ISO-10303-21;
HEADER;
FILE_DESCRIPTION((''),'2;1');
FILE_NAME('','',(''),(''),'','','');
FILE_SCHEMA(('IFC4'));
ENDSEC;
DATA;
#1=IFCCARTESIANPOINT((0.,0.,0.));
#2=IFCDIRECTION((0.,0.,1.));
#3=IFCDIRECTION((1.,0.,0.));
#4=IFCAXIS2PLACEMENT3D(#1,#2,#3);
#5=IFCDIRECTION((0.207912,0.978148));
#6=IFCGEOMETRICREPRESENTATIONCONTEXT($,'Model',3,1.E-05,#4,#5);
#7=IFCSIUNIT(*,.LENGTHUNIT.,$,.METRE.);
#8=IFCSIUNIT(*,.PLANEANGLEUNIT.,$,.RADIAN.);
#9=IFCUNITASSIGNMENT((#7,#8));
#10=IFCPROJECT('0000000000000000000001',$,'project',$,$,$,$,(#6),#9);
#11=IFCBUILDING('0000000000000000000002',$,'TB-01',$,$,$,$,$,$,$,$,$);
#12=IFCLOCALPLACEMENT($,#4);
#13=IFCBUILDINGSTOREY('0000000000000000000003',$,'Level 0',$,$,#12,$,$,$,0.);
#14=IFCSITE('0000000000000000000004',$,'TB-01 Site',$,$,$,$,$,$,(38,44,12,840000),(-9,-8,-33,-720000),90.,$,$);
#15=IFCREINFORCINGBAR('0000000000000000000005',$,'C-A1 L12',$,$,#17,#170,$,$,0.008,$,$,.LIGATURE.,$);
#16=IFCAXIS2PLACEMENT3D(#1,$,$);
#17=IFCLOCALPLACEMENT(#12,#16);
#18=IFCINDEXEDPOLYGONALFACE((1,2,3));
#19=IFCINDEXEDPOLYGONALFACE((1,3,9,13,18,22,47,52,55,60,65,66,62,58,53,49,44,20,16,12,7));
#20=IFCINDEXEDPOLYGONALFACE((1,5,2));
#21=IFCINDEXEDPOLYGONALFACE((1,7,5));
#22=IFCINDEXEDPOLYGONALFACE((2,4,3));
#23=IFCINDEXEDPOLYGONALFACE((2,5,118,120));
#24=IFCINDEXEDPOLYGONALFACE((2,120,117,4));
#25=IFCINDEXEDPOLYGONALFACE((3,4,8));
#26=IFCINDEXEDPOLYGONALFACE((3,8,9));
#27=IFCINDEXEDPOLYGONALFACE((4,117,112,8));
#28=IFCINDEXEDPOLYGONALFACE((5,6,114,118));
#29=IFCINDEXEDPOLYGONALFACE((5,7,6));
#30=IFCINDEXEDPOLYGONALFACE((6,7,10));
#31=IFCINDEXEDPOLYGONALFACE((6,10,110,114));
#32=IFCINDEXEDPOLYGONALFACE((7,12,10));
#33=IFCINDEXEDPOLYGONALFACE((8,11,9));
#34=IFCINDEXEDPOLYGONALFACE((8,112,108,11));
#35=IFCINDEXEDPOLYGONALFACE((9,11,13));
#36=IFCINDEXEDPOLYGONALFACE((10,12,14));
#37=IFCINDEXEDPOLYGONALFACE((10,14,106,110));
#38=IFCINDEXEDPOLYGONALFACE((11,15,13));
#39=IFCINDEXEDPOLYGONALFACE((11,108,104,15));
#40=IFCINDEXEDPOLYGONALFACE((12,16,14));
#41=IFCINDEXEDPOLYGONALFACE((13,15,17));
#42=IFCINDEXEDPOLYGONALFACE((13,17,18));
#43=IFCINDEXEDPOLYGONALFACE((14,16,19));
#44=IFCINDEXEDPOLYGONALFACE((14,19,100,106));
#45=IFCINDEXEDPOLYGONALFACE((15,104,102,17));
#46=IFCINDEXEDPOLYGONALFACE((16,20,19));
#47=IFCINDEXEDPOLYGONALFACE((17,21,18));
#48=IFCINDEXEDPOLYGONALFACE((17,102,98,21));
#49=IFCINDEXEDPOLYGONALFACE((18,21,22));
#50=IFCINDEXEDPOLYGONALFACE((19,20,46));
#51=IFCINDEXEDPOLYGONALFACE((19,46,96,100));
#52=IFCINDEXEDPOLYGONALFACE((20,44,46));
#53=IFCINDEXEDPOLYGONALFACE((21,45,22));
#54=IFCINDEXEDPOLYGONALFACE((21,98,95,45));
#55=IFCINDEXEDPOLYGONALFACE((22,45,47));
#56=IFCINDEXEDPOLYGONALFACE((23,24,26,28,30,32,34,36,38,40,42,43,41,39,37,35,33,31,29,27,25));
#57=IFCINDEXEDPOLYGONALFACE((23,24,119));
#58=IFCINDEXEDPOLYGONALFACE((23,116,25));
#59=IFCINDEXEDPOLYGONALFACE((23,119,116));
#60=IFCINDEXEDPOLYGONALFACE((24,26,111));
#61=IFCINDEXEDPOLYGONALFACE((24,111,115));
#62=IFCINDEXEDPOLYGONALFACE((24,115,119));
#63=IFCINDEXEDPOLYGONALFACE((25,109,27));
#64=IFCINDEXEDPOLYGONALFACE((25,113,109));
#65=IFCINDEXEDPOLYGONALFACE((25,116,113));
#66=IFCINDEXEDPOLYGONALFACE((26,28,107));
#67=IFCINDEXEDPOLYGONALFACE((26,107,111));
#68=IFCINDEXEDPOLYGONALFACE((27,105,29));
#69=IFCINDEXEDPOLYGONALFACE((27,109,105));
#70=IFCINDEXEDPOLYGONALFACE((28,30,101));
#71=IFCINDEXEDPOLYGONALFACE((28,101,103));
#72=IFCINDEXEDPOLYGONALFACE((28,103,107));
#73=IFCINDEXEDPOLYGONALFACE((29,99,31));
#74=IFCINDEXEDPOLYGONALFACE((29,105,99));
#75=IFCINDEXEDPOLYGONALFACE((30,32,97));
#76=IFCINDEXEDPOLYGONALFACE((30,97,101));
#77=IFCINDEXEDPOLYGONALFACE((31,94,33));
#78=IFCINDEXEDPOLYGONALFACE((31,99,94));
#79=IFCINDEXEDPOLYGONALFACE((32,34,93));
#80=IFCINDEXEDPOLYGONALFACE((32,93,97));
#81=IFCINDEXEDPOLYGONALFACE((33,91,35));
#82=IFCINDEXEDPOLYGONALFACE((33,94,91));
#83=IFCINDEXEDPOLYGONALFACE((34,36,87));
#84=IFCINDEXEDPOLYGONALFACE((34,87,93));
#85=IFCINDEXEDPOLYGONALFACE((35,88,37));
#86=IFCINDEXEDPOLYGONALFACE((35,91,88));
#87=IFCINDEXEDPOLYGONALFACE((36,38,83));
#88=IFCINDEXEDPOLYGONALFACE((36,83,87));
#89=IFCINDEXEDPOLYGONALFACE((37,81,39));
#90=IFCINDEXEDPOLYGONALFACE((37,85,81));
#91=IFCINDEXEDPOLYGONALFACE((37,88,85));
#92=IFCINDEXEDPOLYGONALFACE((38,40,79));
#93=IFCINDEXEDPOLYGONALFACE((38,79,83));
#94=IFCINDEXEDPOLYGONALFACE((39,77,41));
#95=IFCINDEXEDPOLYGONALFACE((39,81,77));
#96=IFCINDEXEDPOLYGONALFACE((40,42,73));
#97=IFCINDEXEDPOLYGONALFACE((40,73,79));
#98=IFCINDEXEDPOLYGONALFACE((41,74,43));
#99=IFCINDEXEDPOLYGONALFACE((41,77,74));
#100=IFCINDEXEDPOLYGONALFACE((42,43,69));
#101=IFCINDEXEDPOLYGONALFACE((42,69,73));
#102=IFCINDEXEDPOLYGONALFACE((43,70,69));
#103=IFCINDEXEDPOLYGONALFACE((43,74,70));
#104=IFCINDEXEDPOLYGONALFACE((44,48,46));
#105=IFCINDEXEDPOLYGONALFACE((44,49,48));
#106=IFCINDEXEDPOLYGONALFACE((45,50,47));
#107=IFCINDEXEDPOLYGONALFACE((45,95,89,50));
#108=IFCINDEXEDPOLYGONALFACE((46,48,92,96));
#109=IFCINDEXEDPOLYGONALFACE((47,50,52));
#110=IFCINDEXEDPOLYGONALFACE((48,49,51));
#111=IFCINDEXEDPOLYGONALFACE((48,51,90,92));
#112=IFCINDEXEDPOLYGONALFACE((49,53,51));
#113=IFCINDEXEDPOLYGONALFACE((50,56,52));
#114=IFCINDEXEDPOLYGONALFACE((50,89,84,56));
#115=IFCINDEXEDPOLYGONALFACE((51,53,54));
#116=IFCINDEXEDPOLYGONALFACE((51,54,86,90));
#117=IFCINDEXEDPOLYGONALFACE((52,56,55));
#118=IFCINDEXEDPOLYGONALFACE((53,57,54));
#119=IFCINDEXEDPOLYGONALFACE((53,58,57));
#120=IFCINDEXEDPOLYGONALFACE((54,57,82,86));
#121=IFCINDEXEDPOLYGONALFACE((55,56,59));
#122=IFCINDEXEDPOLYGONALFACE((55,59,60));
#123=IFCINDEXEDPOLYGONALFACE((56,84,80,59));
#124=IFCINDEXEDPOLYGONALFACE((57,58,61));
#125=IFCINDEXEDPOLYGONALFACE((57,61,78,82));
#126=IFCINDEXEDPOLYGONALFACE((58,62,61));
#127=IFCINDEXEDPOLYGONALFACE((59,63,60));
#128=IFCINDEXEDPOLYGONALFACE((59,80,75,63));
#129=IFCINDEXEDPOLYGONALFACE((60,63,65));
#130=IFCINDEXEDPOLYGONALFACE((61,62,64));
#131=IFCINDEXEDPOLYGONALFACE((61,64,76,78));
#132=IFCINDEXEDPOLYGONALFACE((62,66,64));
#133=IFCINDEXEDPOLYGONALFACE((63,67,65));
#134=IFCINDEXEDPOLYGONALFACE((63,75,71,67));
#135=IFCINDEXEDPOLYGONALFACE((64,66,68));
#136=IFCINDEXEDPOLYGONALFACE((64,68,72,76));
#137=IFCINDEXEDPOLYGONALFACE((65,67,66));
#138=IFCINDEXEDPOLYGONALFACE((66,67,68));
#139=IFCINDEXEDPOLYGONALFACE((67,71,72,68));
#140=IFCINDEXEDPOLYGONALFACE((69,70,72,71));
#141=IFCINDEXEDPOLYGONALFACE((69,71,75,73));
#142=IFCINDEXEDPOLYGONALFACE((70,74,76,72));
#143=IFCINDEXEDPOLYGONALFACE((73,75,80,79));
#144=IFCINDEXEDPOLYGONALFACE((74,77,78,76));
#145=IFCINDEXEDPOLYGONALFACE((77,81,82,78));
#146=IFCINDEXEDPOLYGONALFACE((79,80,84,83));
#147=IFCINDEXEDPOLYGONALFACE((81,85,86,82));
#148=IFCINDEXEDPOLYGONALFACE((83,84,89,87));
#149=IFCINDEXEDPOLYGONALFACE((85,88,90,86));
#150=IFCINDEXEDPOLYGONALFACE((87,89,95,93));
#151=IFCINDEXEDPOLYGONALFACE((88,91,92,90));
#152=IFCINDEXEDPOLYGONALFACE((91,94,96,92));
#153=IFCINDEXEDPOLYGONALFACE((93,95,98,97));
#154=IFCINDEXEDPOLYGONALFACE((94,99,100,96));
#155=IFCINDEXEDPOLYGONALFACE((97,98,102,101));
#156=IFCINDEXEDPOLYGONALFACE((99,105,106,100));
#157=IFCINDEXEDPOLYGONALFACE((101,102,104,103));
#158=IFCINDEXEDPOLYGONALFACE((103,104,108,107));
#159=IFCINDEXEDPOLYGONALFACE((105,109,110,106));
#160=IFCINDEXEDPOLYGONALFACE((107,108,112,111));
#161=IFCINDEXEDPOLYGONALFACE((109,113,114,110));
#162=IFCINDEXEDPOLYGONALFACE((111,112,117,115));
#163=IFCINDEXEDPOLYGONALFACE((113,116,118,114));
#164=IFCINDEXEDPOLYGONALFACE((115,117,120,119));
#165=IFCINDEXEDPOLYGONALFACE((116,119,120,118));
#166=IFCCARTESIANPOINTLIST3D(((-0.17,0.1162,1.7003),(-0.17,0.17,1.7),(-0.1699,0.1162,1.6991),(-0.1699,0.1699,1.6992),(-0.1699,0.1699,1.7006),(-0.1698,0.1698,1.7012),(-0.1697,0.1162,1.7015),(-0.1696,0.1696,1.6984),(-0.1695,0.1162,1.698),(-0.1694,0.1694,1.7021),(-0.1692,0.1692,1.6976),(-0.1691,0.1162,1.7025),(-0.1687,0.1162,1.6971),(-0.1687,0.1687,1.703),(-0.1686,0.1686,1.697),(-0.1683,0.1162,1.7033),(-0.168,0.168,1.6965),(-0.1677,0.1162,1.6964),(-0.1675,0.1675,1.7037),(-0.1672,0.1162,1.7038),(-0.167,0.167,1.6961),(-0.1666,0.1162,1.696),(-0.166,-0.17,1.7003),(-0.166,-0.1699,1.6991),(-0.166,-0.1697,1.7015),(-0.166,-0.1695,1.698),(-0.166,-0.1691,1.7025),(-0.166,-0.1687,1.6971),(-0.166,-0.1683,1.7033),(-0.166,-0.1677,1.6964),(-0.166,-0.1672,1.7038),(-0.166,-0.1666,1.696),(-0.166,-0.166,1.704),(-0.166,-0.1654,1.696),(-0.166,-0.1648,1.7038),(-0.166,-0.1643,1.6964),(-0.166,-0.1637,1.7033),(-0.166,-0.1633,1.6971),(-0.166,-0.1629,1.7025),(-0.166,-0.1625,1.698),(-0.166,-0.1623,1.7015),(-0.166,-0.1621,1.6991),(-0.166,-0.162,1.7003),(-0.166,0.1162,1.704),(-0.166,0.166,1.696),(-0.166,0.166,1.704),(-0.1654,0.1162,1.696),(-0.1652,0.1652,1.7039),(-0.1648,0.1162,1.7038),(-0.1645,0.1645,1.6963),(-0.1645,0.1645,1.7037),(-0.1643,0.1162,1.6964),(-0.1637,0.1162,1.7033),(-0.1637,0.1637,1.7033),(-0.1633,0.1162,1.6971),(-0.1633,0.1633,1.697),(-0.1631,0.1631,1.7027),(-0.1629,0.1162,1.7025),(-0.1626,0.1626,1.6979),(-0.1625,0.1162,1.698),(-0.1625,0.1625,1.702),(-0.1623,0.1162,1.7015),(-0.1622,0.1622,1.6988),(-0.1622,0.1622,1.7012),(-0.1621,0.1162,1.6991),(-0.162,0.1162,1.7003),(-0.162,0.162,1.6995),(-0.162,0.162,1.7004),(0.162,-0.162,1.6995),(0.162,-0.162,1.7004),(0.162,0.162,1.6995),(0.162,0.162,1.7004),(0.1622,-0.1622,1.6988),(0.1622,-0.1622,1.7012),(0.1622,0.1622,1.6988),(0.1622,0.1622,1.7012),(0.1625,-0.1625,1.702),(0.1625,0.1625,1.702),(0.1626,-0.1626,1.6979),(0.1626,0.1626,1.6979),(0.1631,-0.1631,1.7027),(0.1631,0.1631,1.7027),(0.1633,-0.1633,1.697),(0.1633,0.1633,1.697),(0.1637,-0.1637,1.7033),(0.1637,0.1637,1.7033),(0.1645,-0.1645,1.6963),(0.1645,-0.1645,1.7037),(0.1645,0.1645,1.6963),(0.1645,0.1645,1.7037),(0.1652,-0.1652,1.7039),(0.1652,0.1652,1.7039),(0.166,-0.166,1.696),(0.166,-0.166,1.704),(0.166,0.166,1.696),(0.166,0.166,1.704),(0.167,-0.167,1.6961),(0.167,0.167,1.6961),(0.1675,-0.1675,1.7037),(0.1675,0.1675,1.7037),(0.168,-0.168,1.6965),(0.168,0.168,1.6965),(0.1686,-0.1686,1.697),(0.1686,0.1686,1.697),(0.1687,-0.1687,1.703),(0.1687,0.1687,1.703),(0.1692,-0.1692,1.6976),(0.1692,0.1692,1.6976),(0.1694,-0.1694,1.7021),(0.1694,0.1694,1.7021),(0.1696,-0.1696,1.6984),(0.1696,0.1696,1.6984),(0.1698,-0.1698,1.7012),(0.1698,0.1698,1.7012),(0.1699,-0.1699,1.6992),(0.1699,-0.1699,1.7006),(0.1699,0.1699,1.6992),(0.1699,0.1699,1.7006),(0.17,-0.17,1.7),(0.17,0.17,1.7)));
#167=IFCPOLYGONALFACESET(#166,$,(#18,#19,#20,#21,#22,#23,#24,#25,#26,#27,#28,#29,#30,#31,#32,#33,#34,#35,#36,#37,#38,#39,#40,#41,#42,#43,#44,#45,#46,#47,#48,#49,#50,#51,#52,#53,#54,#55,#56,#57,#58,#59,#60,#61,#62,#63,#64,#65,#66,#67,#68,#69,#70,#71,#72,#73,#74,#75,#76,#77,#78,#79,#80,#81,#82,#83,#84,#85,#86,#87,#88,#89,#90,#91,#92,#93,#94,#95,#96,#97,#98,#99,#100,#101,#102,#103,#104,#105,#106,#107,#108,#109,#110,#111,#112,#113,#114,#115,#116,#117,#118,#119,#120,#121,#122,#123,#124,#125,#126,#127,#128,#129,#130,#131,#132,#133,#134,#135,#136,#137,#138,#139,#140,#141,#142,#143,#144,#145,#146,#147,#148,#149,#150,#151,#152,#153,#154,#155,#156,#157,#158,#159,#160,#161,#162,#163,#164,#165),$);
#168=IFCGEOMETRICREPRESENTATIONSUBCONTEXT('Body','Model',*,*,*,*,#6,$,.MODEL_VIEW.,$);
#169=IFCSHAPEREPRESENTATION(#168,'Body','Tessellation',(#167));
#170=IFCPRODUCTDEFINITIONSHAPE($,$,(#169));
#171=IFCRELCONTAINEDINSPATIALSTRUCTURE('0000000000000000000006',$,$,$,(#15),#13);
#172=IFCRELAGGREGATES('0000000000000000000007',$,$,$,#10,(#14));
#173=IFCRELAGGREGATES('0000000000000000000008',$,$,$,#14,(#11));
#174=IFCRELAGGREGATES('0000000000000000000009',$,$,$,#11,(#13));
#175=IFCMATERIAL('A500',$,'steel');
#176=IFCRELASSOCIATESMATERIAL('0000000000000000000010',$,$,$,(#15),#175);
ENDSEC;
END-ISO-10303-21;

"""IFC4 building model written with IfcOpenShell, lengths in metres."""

from ifc_helpers import new_model, entity, si_unit, direction, origin_with_axes, place, context, subcontext, project, spatial, material, element, save


model = new_model("IFC4")

# Units and contexts
model_context = context("Model", 3, precision=1e-05, world=origin_with_axes(), true_north=direction((0.207912, 0.978148)))
body_context = subcontext(model_context, "Body", "Model", "MODEL_VIEW")
ifc_project = project(units=[si_unit("LENGTHUNIT", "METRE"), si_unit("PLANEANGLEUNIT", "RADIAN")], contexts=[model_context])

# Site, building, storey
site = spatial("IfcSite", under=ifc_project, Name="TB-01 Site", RefLatitude=(38, 44, 12, 840000), RefLongitude=(-9, -8, -33, -720000), RefElevation=90.0)
building = spatial("IfcBuilding", under=site, Name="TB-01")
storey_placement = place(None, origin_with_axes())
storey = spatial("IfcBuildingStorey", under=building, at=storey_placement, Name="Level 0", Elevation=0.0)

# Reinforcing bar
ifc_material_1 = material(Name="A500", Category="steel")
reinforcing_bar_1_placement = place(storey_placement, origin_with_axes())
element("IfcReinforcingBar", 1, at=reinforcing_bar_1_placement, inside=storey, material=ifc_material_1, Name="C-A1 L12", NominalDiameter=0.008, PredefinedType="LIGATURE", context=body_context, shape_type="AdvancedSweptSolid", body=[
    entity("IfcSweptDiskSolid", entity("IfcPolyline", [entity("IfcCartesianPoint", [-0.166, -0.166, 1.7]), entity("IfcCartesianPoint", [0.166, -0.166, 1.7]), entity("IfcCartesianPoint", [0.166, 0.166, 1.7]), entity("IfcCartesianPoint", [-0.166, 0.166, 1.7]), entity("IfcCartesianPoint", [-0.166, 0.1162, 1.7])]), 0.004),
])

save(model, "model.ifc")
